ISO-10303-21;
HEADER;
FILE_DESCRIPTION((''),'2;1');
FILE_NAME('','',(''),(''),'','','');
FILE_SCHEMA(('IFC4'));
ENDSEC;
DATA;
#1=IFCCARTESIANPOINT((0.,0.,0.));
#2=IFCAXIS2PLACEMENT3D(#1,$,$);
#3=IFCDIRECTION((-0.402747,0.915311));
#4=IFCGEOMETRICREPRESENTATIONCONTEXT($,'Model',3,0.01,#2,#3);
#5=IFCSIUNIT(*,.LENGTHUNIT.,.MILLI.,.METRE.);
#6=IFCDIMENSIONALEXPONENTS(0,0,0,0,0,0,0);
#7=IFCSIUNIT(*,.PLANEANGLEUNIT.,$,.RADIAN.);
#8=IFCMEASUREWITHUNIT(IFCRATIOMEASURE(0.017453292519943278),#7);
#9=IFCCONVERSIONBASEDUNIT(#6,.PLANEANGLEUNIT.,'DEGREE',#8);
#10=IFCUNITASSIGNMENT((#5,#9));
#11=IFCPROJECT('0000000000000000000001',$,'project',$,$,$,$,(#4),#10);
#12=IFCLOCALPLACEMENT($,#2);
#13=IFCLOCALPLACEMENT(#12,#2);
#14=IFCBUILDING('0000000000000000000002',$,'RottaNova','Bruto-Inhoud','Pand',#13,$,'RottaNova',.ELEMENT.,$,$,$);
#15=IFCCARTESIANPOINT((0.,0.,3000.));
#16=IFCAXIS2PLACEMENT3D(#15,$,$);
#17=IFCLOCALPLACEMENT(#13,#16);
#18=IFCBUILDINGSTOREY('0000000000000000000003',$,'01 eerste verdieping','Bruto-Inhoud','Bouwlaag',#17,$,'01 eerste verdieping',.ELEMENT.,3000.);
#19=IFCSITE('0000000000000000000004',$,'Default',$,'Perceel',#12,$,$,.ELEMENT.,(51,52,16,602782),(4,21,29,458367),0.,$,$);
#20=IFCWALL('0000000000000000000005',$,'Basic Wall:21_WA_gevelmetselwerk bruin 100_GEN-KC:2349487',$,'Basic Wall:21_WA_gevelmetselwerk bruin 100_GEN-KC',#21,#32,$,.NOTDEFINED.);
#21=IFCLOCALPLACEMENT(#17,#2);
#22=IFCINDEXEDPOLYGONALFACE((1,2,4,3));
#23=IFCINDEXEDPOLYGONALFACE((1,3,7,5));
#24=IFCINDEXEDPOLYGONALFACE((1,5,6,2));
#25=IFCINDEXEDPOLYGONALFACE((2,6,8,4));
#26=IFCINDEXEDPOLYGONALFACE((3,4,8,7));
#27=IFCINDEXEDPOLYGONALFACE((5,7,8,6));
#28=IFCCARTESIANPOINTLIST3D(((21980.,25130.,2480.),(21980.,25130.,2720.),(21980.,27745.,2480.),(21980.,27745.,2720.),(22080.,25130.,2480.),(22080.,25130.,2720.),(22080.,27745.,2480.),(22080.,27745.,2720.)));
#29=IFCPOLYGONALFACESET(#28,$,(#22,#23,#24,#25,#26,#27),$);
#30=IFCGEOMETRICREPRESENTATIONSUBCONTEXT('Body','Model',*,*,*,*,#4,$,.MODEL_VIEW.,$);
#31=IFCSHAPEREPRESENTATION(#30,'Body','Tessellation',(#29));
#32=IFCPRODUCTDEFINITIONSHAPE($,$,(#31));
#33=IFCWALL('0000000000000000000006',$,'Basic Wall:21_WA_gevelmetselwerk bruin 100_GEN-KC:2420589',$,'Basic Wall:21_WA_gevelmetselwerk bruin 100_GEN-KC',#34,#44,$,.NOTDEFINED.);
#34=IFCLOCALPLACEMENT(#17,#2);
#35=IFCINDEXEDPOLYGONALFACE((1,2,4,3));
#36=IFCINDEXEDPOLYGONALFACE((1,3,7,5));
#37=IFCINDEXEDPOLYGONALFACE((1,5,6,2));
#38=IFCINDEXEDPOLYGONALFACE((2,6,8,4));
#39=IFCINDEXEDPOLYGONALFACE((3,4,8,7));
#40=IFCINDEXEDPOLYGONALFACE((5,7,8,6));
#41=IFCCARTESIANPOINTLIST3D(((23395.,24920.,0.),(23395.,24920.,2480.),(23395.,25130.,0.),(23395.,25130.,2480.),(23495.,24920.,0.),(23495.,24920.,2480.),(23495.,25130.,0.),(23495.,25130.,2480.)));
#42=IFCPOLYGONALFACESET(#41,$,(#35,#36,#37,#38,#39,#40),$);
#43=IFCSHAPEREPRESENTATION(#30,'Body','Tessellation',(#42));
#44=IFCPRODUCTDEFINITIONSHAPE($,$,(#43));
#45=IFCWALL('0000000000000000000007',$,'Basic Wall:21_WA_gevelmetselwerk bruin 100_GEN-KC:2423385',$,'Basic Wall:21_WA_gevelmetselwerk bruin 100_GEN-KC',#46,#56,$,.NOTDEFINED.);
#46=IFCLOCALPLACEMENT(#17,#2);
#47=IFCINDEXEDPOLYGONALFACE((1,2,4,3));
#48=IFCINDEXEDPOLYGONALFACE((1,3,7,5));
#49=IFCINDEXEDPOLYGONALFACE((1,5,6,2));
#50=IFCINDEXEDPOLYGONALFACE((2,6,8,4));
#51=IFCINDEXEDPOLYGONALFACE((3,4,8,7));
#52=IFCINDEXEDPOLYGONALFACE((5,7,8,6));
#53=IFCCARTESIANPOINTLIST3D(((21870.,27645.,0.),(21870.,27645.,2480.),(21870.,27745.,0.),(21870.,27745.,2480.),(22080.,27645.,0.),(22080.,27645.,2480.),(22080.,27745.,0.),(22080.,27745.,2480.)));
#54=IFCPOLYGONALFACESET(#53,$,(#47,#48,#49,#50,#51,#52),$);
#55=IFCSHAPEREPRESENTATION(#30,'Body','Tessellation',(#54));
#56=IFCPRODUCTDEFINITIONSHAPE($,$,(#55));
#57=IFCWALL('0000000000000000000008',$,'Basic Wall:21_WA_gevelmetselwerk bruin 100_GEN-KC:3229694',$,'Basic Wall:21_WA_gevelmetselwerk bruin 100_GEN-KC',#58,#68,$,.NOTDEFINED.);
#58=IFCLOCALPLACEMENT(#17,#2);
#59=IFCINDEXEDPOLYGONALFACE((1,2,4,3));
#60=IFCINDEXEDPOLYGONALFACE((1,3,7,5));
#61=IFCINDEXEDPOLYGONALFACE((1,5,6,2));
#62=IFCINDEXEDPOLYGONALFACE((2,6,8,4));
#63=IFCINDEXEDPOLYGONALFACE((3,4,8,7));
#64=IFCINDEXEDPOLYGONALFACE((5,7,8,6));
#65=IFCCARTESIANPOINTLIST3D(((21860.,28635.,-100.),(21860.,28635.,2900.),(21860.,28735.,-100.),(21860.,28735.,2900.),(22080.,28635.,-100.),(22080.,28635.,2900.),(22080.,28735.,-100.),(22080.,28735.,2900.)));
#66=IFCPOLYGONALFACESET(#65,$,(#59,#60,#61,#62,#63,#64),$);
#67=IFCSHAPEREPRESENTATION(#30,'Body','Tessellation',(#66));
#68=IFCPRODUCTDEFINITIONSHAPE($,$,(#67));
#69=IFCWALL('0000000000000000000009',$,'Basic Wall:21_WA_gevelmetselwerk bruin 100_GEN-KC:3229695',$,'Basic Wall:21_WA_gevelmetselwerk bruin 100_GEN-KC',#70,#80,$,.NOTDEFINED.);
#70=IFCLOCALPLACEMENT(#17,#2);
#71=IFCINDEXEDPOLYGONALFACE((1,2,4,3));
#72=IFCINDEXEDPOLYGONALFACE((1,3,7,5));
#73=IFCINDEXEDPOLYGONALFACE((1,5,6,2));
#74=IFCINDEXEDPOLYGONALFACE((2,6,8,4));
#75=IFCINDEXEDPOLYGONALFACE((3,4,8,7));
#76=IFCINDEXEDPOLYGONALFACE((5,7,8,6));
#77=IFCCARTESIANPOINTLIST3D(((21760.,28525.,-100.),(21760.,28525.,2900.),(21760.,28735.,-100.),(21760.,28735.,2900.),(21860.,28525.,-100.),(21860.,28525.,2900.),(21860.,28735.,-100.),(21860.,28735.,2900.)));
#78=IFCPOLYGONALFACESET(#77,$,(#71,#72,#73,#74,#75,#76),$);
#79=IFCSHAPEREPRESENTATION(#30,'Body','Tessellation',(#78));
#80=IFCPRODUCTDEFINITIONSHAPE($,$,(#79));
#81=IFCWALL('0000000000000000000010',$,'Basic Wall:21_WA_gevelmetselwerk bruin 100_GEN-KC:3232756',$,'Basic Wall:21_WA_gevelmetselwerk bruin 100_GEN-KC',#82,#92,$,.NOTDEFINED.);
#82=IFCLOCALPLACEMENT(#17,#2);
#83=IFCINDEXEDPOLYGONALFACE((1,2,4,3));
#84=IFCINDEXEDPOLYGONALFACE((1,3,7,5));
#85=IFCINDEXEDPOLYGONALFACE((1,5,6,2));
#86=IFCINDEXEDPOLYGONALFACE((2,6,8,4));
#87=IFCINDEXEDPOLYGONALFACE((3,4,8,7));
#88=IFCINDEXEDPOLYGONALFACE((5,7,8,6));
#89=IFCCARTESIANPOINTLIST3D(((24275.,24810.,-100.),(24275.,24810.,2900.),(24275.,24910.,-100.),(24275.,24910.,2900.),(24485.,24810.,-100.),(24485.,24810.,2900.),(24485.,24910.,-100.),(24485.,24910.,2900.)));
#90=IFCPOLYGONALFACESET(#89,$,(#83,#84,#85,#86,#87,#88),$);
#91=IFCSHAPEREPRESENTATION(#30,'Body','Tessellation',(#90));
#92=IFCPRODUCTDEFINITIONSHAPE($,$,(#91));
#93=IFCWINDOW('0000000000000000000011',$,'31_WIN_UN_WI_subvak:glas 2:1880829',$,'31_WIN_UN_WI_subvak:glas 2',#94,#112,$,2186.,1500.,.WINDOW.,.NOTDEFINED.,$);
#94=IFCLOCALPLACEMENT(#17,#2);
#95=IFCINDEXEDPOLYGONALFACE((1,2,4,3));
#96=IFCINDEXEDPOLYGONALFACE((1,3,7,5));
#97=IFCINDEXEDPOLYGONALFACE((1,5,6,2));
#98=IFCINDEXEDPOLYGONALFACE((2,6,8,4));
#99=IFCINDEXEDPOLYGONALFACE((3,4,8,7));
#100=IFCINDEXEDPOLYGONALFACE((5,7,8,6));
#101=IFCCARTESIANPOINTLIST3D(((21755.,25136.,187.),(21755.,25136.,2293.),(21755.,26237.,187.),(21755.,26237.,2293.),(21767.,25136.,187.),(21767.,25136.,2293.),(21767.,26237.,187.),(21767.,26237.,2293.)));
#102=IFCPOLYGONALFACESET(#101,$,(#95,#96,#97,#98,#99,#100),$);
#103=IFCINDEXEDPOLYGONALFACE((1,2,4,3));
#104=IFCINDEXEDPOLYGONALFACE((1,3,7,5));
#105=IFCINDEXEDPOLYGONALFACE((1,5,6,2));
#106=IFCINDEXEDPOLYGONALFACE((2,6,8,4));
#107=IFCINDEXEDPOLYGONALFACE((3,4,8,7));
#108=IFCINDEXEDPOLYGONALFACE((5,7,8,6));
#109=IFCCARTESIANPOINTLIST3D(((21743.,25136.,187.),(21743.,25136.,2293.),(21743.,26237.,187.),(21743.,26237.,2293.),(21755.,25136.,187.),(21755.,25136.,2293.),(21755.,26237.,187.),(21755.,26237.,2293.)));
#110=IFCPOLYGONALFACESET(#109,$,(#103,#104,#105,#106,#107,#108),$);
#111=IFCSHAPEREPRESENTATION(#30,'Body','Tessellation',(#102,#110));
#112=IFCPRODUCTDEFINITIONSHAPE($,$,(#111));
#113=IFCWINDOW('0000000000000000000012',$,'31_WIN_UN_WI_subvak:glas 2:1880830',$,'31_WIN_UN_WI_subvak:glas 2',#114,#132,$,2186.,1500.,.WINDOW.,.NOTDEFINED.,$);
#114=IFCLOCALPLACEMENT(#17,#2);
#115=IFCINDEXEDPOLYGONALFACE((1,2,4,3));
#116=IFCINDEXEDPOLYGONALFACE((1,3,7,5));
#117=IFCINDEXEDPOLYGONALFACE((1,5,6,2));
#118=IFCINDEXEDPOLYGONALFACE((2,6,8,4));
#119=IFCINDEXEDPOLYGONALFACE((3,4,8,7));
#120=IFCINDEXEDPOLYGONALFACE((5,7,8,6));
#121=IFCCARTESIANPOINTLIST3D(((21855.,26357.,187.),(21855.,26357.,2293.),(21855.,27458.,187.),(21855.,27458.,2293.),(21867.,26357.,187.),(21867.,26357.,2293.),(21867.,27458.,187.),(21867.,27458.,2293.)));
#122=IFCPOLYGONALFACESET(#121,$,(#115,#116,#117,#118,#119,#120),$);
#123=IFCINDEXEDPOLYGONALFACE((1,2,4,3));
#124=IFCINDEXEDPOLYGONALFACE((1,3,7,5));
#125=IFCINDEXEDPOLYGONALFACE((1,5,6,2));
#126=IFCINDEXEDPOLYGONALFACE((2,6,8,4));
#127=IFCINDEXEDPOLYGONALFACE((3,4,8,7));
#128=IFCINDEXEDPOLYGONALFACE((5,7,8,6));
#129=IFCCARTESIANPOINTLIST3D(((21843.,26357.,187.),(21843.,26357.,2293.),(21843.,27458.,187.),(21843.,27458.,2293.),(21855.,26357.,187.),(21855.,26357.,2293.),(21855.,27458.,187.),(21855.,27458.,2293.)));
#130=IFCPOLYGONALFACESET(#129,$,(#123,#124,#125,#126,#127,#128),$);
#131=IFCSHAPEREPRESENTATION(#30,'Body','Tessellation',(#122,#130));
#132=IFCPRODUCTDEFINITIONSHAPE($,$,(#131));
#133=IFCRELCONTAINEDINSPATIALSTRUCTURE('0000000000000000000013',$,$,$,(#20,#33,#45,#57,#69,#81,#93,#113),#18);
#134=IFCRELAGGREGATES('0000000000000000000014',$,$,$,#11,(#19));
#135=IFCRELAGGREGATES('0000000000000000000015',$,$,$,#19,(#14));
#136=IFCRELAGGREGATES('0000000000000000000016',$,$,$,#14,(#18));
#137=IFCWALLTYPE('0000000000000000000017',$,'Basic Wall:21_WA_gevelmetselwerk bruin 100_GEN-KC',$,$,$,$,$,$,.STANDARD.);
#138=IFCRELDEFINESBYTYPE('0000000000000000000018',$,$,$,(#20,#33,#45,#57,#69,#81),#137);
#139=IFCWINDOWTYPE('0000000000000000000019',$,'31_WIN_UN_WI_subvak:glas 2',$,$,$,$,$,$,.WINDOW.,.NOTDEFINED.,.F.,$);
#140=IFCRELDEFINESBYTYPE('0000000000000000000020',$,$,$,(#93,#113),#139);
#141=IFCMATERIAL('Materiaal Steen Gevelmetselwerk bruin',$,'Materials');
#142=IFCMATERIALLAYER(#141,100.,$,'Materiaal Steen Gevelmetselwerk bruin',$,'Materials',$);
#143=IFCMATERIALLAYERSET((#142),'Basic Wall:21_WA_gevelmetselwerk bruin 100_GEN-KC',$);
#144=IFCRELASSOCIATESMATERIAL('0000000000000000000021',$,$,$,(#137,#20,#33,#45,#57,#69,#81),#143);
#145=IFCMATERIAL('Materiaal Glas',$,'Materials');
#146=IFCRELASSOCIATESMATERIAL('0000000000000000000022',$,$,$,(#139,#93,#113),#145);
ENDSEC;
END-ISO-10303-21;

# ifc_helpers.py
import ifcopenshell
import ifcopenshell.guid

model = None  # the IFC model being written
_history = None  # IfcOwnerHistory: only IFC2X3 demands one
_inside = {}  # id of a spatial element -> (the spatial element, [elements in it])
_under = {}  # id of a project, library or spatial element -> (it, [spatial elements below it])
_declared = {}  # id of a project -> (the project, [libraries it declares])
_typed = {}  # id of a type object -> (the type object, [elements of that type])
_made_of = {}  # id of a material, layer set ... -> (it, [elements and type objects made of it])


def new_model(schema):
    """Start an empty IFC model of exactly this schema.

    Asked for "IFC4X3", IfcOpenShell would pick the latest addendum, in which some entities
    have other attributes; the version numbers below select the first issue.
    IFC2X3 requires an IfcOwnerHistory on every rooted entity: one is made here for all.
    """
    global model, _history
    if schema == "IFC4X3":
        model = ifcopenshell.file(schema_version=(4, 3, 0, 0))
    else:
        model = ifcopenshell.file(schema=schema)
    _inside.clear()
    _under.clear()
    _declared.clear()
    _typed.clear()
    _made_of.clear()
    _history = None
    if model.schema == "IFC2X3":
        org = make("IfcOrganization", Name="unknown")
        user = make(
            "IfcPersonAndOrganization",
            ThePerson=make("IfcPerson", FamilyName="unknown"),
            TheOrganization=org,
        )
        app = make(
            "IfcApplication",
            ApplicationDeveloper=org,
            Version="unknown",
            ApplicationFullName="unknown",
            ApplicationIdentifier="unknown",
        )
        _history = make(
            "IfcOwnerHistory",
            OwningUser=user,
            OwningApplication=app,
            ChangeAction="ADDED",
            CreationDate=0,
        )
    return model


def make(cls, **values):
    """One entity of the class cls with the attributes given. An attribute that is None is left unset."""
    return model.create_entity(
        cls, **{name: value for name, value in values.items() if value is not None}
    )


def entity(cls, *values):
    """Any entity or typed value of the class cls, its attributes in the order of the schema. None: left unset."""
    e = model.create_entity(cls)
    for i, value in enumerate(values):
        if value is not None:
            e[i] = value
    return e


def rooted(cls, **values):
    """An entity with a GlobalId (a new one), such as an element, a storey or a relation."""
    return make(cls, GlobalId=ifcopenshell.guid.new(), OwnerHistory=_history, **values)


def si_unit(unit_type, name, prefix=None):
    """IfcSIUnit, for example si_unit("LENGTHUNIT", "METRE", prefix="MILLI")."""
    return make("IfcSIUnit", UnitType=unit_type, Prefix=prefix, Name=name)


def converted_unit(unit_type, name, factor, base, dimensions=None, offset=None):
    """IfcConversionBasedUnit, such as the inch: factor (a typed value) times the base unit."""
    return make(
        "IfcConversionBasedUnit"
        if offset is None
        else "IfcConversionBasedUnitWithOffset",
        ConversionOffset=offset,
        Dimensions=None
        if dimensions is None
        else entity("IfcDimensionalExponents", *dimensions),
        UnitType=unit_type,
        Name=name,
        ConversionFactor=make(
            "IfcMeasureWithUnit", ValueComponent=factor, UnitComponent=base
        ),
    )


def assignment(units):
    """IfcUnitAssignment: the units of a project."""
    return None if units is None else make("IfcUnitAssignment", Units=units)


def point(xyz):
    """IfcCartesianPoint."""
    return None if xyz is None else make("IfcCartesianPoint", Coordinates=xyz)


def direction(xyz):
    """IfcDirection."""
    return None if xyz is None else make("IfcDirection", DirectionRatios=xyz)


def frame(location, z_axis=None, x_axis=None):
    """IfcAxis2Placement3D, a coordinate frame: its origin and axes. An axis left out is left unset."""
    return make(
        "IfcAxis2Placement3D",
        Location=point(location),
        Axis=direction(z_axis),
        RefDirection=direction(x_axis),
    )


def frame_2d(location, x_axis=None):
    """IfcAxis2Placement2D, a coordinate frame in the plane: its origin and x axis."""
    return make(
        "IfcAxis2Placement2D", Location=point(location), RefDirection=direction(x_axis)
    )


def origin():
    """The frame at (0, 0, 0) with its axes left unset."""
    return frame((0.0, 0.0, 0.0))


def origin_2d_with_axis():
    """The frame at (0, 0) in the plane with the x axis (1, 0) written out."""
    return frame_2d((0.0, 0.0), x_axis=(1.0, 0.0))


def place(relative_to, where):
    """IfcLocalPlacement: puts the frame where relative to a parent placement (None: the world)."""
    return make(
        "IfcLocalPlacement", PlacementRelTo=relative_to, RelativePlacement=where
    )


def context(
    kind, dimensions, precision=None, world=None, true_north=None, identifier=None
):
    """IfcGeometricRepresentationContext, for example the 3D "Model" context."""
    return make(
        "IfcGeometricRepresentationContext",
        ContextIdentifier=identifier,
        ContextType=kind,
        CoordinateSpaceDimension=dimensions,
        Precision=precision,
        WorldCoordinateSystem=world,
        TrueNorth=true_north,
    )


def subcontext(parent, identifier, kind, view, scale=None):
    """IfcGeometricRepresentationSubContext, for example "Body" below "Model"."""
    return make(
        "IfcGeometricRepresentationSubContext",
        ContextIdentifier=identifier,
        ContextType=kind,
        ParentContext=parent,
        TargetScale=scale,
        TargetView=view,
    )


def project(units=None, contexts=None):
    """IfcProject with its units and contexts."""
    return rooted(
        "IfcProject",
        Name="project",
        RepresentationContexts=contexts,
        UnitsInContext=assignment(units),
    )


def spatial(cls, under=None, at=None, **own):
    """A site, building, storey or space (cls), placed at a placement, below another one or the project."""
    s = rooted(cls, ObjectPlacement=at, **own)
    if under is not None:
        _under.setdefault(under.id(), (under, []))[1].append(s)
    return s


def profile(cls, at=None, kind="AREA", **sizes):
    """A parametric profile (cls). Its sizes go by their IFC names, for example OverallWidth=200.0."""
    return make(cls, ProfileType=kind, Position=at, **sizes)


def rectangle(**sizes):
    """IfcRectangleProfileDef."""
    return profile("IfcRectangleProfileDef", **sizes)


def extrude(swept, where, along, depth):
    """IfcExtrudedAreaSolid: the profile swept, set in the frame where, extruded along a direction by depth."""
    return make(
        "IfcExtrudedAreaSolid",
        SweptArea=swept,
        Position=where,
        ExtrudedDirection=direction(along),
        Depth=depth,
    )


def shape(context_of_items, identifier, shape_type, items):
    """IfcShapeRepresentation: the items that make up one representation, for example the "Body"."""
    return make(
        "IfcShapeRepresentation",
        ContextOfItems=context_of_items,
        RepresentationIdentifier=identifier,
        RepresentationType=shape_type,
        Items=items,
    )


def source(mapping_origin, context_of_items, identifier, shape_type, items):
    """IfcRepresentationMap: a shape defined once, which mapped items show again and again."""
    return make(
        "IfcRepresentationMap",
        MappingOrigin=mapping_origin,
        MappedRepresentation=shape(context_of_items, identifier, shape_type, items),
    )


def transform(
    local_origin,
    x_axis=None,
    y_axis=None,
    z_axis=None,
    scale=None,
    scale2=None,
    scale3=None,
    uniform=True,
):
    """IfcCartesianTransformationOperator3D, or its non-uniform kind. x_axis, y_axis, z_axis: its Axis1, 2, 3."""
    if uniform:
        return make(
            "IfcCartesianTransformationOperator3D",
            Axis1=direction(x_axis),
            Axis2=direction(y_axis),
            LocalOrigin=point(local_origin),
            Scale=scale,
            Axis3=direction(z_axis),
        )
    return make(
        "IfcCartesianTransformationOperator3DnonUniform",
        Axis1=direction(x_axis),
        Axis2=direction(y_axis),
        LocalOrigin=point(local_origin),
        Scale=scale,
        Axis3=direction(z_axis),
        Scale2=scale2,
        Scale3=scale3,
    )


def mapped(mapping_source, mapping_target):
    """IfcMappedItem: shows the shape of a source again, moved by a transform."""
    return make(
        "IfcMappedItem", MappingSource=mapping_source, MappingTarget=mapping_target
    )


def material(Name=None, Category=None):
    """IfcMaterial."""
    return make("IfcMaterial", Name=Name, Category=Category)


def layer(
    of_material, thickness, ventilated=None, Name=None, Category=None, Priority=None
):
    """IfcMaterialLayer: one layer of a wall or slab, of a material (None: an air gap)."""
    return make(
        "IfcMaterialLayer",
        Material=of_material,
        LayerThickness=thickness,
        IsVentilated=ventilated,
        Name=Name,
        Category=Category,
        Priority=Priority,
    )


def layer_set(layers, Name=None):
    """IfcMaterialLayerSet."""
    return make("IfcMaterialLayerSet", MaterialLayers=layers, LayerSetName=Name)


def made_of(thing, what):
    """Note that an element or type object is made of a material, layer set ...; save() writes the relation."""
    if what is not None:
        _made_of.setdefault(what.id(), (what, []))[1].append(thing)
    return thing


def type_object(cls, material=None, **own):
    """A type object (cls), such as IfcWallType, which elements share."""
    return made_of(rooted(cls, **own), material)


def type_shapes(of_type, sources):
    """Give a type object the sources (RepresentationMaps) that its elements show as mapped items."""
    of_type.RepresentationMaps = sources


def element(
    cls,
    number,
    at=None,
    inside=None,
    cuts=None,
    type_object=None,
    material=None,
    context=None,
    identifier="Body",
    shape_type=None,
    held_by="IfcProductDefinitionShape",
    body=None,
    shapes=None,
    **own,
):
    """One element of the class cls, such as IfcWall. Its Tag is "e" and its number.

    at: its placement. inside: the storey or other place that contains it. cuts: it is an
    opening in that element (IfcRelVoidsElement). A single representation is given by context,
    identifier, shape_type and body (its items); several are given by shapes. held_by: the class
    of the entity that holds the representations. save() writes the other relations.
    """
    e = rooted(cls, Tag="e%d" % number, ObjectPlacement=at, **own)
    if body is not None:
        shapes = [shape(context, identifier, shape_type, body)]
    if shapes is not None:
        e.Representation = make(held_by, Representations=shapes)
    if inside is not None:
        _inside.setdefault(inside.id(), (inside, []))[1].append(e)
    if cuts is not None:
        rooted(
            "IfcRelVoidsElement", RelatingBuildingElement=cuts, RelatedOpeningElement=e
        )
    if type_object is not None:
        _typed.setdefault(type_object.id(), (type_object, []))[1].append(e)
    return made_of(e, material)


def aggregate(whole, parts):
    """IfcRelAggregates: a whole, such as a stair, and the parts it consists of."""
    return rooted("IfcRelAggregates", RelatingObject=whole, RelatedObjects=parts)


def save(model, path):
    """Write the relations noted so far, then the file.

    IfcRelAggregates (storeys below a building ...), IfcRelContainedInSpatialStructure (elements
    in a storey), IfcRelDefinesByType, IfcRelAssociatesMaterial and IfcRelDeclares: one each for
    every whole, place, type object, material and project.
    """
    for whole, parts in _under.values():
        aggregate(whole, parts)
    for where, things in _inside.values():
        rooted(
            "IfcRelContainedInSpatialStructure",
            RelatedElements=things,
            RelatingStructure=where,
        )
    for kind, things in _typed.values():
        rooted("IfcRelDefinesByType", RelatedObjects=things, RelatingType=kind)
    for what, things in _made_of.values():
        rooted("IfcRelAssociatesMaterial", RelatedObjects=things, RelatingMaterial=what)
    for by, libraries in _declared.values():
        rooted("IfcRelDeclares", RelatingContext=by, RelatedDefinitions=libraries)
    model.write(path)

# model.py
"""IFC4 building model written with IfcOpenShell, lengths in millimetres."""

from ifc_helpers import new_model, entity, si_unit, converted_unit, direction, frame, frame_2d, origin, origin_2d_with_axis, place, context, subcontext, project, spatial, rectangle, extrude, source, transform, mapped, material, layer, layer_set, type_object, type_shapes, element, save


model = new_model("IFC4")

# Units and contexts
model_context = context("Model", 3, precision=0.01, world=origin(), true_north=direction((-0.402747, 0.915311)))
body_context = subcontext(model_context, "Body", "Model", "MODEL_VIEW")
ifc_project = project(units=[si_unit("LENGTHUNIT", "METRE", prefix="MILLI"), converted_unit("PLANEANGLEUNIT", "DEGREE", entity("IfcRatioMeasure", 0.017453292519943278), si_unit("PLANEANGLEUNIT", "RADIAN"), dimensions=[0, 0, 0, 0, 0, 0, 0])], contexts=[model_context])

# Site, building, storey
site_placement = place(None, origin())
site = spatial("IfcSite", under=ifc_project, at=site_placement, Name="Default", ObjectType="Perceel", CompositionType="ELEMENT", RefLatitude=(51, 52, 16, 602782), RefLongitude=(4, 21, 29, 458367), RefElevation=0.0)
building_placement = place(site_placement, origin())
building = spatial("IfcBuilding", under=site, at=building_placement, Name="RottaNova", Description="Bruto-Inhoud", ObjectType="Pand", LongName="RottaNova", CompositionType="ELEMENT")
storey_placement = place(building_placement, frame((0.0, 0.0, 3000.0)))
storey = spatial("IfcBuildingStorey", under=building, at=storey_placement, Name="01 eerste verdieping", Description="Bruto-Inhoud", ObjectType="Bouwlaag", LongName="01 eerste verdieping", CompositionType="ELEMENT", Elevation=3000.0)

# Shared definitions
ifc_material_1 = material(Name="Materiaal Glas", Category="Materials")

# Walls
ifc_material_2 = material(Name="Materiaal Steen Gevelmetselwerk bruin", Category="Materials")
ifc_layer_1 = layer(ifc_material_2, 100.0, Name="Materiaal Steen Gevelmetselwerk bruin", Category="Materials")
ifc_layer_set_1 = layer_set([ifc_layer_1], Name="Basic Wall:21_WA_gevelmetselwerk bruin 100_GEN-KC")
wall_type_1 = type_object("IfcWallType", Name="Basic Wall:21_WA_gevelmetselwerk bruin 100_GEN-KC", PredefinedType="STANDARD", material=ifc_layer_set_1)
wall_1_placement = place(storey_placement, frame((22030.0, 25130.0, 2480.0), z_axis=(0.0, 0.0, 1.0), x_axis=(0.0, 1.0, 0.0)))
element("IfcWall", 1, at=wall_1_placement, inside=storey, type_object=wall_type_1, material=ifc_layer_set_1, Name="Basic Wall:21_WA_gevelmetselwerk bruin 100_GEN-KC:2349487", ObjectType="Basic Wall:21_WA_gevelmetselwerk bruin 100_GEN-KC", PredefinedType="NOTDEFINED", context=body_context, shape_type="SweptSolid", body=[
    extrude(rectangle(XDim=2615.0, YDim=100.0, at=frame_2d((1307.5, 0.0), x_axis=(-1.0, 0.0))), origin(), (0.0, 0.0, 1.0), 240.0),
])
wall_2_placement = place(storey_placement, frame((23445.0, 24920.0, 0.0), z_axis=(0.0, 0.0, 1.0), x_axis=(0.0, 1.0, 0.0)))
element("IfcWall", 2, at=wall_2_placement, inside=storey, type_object=wall_type_1, material=ifc_layer_set_1, Name="Basic Wall:21_WA_gevelmetselwerk bruin 100_GEN-KC:2420589", ObjectType="Basic Wall:21_WA_gevelmetselwerk bruin 100_GEN-KC", PredefinedType="NOTDEFINED", context=body_context, shape_type="SweptSolid", body=[
    extrude(rectangle(XDim=210.0, YDim=100.0, at=frame_2d((105.0, 0.0), x_axis=(-1.0, 0.0))), origin(), (0.0, 0.0, 1.0), 2480.0),
])
wall_3_placement = place(storey_placement, frame((21870.0, 27695.0, 0.0)))
element("IfcWall", 3, at=wall_3_placement, inside=storey, type_object=wall_type_1, material=ifc_layer_set_1, Name="Basic Wall:21_WA_gevelmetselwerk bruin 100_GEN-KC:2423385", ObjectType="Basic Wall:21_WA_gevelmetselwerk bruin 100_GEN-KC", PredefinedType="NOTDEFINED", context=body_context, shape_type="SweptSolid", body=[
    extrude(rectangle(XDim=210.0, YDim=100.0, at=frame_2d((105.0, 0.0), x_axis=(-1.0, 0.0))), origin(), (0.0, 0.0, 1.0), 2480.0),
])
wall_4_placement = place(storey_placement, frame((21860.0, 28685.0, -100.0)))
element("IfcWall", 4, at=wall_4_placement, inside=storey, type_object=wall_type_1, material=ifc_layer_set_1, Name="Basic Wall:21_WA_gevelmetselwerk bruin 100_GEN-KC:3229694", ObjectType="Basic Wall:21_WA_gevelmetselwerk bruin 100_GEN-KC", PredefinedType="NOTDEFINED", context=body_context, shape_type="SweptSolid", body=[
    extrude(rectangle(XDim=220.0, YDim=100.0, at=frame_2d((110.0, 0.0), x_axis=(-1.0, 0.0))), origin(), (0.0, 0.0, 1.0), 3000.0),
])
for number, where, z_axis, x_axis, name in (
    (5, (21810.0, 28735.0, -100.0), (0.0, 0.0, 1.0), (0.0, -1.0, 0.0), "Basic Wall:21_WA_gevelmetselwerk bruin 100_GEN-KC:3229695"),
    (6, (24485.0, 24860.0, -100.0), (0.0, 0.0, 1.0), (-1.0, 0.0, 0.0), "Basic Wall:21_WA_gevelmetselwerk bruin 100_GEN-KC:3232756"),
):
    element("IfcWall", number, at=place(storey_placement, frame(where, z_axis=z_axis, x_axis=x_axis)), inside=storey, type_object=wall_type_1, material=ifc_layer_set_1, Name=name, ObjectType="Basic Wall:21_WA_gevelmetselwerk bruin 100_GEN-KC", PredefinedType="NOTDEFINED", context=body_context, shape_type="SweptSolid", body=[
        extrude(rectangle(XDim=210.0, YDim=100.0, at=frame_2d((105.0, 0.0), x_axis=(-1.0, 0.0))), origin(), (0.0, 0.0, 1.0), 3000.0),
    ])

# Windows
window_type = type_object("IfcWindowType", Name="31_WIN_UN_WI_subvak:glas 2", ParameterTakesPrecedence=False, PartitioningType="NOTDEFINED", PredefinedType="WINDOW", material=ifc_material_1)
shared_shape_1 = source(origin(), body_context, "Body", "SweptSolid", [
    extrude(rectangle(XDim=12.0, YDim=1101.0, at=frame_2d((0.0, 0.0), x_axis=(1.0, 0.0))), frame((0.0, 6.0, 0.0), z_axis=(0.0, 0.0, 1.0), x_axis=(0.0, -1.0, 0.0)), (0.0, 0.0, 1.0), 2106.0),
    extrude(rectangle(XDim=12.0, YDim=1101.0, at=origin_2d_with_axis()), frame((0.0, -6.0, 0.0), z_axis=(0.0, 0.0, 1.0), x_axis=(0.0, -1.0, 0.0)), (0.0, 0.0, 1.0), 2106.0),
])
type_shapes(window_type, [shared_shape_1])
for number, where, z_axis, x_axis, name in (
    (7, (21755.0, 25686.5, 187.0), (0.0, 0.0, 1.0), (0.0, -1.0, 0.0), "31_WIN_UN_WI_subvak:glas 2:1880829"),
    (8, (21855.0, 26907.5, 187.0), (0.0, 0.0, 1.0), (0.0, -1.0, 0.0), "31_WIN_UN_WI_subvak:glas 2:1880830"),
):
    element("IfcWindow", number, at=place(storey_placement, frame(where, z_axis=z_axis, x_axis=x_axis)), inside=storey, type_object=window_type, material=ifc_material_1, Name=name, ObjectType="31_WIN_UN_WI_subvak:glas 2", OverallHeight=2186.0, OverallWidth=1500.0, PartitioningType="NOTDEFINED", PredefinedType="WINDOW", context=body_context, shape_type="MappedRepresentation", body=[
        mapped(shared_shape_1, transform((0.0, 0.0, 0.0), scale=1.0)),
    ])

save(model, "model.ifc")
